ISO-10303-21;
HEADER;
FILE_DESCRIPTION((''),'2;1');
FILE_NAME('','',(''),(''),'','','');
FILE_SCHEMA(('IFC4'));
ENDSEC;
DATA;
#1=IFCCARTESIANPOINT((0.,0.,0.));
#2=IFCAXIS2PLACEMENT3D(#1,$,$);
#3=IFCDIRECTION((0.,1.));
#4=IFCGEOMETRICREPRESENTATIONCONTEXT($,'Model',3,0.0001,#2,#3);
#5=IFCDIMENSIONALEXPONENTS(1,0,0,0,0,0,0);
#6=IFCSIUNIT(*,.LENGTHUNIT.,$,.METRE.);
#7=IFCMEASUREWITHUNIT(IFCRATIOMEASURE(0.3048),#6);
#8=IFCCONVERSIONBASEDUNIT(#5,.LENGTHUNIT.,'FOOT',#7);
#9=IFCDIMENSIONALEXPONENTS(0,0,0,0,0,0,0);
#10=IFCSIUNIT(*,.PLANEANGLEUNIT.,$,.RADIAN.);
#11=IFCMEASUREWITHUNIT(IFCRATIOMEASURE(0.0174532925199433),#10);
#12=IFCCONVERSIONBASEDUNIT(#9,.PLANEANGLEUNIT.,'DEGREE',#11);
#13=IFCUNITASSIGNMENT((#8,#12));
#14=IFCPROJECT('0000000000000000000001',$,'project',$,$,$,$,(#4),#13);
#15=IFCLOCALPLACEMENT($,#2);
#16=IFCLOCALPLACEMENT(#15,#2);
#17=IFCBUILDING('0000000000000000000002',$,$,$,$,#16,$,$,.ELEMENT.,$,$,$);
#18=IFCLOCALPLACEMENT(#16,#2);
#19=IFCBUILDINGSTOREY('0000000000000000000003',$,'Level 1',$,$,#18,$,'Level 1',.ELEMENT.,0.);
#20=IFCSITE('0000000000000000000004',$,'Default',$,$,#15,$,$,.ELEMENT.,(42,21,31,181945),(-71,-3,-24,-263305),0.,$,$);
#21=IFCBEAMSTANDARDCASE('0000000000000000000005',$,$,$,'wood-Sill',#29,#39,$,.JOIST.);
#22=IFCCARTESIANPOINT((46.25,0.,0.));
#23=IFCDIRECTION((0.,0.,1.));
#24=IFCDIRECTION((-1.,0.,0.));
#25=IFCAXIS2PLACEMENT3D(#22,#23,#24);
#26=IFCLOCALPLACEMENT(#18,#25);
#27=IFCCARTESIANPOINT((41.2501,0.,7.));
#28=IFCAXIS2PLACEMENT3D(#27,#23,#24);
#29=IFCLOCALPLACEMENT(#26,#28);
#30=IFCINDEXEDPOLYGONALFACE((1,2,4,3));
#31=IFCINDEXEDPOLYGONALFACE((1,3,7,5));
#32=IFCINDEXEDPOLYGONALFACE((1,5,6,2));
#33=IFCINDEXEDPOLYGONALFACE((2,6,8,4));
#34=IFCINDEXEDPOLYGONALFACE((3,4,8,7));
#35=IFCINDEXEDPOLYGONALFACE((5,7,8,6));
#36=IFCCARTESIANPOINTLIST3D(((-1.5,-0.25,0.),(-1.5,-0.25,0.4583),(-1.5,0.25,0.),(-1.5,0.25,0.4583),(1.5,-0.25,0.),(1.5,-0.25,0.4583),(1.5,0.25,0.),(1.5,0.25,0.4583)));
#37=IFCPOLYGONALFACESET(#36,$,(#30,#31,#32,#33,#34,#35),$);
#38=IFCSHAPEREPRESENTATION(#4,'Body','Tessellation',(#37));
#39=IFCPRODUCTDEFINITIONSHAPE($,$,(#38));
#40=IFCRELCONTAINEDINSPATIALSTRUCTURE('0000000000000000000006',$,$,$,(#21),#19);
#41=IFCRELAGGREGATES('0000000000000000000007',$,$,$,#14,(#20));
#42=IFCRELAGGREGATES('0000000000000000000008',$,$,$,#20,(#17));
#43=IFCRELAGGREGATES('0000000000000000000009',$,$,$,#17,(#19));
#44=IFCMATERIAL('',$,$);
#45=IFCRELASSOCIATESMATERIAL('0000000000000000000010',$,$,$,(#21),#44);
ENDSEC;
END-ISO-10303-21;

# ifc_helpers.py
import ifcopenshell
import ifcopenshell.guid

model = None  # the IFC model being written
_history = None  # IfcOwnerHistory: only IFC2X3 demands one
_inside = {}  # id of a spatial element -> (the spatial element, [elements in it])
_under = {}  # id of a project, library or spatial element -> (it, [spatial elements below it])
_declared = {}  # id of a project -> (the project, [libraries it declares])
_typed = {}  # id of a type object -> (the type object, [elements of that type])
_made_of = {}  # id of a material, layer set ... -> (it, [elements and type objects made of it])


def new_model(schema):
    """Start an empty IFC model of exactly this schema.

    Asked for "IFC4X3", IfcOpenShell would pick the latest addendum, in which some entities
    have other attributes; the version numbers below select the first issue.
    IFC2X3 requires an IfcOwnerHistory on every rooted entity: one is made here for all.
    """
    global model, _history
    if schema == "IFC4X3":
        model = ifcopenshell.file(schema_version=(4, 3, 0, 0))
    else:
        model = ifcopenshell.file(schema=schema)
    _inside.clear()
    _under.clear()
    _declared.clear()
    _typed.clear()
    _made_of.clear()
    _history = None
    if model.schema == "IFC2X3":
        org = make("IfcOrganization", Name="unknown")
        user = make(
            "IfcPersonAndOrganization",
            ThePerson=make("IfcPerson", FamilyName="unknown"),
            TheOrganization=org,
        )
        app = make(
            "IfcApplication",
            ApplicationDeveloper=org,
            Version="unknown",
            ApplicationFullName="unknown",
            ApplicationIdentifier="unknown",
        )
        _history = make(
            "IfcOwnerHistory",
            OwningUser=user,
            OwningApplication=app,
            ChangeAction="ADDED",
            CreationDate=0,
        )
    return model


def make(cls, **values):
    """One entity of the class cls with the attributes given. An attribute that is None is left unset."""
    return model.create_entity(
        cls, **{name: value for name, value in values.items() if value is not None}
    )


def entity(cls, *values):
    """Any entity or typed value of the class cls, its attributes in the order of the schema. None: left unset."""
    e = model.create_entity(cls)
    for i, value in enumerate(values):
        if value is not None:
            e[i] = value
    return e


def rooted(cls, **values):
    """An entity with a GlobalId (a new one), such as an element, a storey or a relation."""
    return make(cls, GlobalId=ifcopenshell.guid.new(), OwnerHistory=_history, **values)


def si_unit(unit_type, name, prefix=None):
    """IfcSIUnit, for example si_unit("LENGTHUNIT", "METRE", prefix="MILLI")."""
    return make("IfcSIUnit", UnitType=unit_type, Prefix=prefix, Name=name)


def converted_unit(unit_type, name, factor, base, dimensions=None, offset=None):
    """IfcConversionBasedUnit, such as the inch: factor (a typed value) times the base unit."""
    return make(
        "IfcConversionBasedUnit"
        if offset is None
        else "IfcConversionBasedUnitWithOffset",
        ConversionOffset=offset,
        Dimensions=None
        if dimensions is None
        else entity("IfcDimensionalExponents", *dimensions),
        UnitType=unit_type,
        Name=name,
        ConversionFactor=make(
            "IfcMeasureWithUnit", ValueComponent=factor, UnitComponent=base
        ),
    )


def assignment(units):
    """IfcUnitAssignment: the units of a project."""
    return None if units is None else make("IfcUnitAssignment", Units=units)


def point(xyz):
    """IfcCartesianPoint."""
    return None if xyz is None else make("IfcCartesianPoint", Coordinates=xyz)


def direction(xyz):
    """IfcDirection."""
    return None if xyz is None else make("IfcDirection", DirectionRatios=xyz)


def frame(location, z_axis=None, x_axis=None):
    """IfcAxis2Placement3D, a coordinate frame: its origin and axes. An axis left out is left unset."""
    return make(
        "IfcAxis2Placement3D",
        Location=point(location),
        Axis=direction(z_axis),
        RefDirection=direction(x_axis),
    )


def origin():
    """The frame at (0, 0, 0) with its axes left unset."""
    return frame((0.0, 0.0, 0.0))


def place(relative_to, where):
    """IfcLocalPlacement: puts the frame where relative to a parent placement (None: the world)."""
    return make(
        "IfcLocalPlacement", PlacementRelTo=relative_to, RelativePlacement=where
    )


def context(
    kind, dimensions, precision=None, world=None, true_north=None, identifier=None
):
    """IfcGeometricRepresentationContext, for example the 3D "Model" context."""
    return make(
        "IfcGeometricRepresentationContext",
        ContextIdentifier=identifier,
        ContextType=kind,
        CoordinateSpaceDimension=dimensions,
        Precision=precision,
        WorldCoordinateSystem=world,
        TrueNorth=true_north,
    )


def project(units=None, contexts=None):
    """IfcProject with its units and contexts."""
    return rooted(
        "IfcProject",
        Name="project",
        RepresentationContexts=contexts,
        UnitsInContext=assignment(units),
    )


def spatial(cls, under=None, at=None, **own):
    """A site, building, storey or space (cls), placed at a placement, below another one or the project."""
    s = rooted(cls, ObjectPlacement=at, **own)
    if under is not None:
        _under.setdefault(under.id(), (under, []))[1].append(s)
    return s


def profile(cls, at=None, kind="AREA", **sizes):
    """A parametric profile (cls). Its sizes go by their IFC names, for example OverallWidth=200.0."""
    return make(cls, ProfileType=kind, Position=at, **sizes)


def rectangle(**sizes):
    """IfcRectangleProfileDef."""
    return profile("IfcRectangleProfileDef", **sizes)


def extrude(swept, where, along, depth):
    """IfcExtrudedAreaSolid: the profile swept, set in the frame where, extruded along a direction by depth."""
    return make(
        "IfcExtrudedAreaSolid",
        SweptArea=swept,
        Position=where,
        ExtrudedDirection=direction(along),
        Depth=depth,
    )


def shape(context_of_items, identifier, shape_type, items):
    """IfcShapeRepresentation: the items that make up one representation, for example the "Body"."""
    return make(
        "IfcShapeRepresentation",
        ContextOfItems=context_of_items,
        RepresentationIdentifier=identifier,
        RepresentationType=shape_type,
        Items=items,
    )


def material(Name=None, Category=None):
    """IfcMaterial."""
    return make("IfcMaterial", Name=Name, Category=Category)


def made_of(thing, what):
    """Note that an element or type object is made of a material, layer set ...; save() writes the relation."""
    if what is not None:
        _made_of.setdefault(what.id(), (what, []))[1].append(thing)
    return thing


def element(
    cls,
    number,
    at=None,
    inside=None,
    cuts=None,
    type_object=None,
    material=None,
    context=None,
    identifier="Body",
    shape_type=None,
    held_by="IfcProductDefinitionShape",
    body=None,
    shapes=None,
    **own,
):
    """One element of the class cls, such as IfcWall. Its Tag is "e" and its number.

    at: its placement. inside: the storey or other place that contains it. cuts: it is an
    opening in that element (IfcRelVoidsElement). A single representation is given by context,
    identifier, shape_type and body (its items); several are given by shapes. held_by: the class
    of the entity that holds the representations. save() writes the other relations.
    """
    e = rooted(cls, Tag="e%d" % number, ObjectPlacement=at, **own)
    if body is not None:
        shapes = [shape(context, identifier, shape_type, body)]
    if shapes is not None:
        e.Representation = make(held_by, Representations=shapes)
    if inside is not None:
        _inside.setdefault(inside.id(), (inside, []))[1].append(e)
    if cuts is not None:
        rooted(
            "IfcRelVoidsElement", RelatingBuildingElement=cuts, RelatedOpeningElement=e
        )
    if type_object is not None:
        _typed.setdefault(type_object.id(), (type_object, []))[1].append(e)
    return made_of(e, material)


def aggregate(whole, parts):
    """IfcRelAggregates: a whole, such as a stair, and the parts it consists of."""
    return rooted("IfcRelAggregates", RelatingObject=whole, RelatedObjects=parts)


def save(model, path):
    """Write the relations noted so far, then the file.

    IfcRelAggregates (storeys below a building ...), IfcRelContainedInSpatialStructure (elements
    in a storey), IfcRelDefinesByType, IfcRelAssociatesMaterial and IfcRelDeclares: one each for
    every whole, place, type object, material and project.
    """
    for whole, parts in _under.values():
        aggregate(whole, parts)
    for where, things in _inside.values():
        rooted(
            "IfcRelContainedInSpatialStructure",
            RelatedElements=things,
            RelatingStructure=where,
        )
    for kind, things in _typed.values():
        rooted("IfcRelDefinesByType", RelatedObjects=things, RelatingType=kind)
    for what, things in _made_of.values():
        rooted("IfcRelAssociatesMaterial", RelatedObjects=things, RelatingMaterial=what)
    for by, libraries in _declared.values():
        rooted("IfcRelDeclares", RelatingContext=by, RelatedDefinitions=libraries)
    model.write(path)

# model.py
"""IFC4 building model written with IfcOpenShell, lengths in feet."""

from ifc_helpers import new_model, entity, si_unit, converted_unit, direction, frame, origin, place, context, project, spatial, rectangle, extrude, material, element, save


model = new_model("IFC4")

# Units and contexts
model_context = context("Model", 3, precision=0.0001, world=origin(), true_north=direction((0.0, 1.0)))
ifc_project = project(units=[converted_unit("LENGTHUNIT", "FOOT", entity("IfcRatioMeasure", 0.3048), si_unit("LENGTHUNIT", "METRE"), dimensions=[1, 0, 0, 0, 0, 0, 0]), converted_unit("PLANEANGLEUNIT", "DEGREE", entity("IfcRatioMeasure", 0.0174532925199433), si_unit("PLANEANGLEUNIT", "RADIAN"), dimensions=[0, 0, 0, 0, 0, 0, 0])], contexts=[model_context])

# Site, building, storey
site_placement = place(None, origin())
site = spatial("IfcSite", under=ifc_project, at=site_placement, Name="Default", CompositionType="ELEMENT", RefLatitude=(42, 21, 31, 181945), RefLongitude=(-71, -3, -24, -263305), RefElevation=0.0)
building_placement = place(site_placement, origin())
building = spatial("IfcBuilding", under=site, at=building_placement, CompositionType="ELEMENT")
storey_placement = place(building_placement, origin())
storey = spatial("IfcBuildingStorey", under=building, at=storey_placement, Name="Level 1", LongName="Level 1", CompositionType="ELEMENT", Elevation=0.0)

# Shared definitions
placement_1 = place(storey_placement, frame((46.25, 0.0, 0.0), z_axis=(0.0, 0.0, 1.0), x_axis=(-1.0, 0.0, 0.0)))

# Beam
ifc_material_1 = material(Name="")
beam_1_placement = place(placement_1, frame((41.2501, 0.0, 7.0), z_axis=(0.0, 0.0, 1.0), x_axis=(-1.0, 0.0, 0.0)))
element("IfcBeamStandardCase", 1, at=beam_1_placement, inside=storey, material=ifc_material_1, ObjectType="wood-Sill", PredefinedType="JOIST", context=model_context, shape_type="SweptSolid", body=[
    extrude(rectangle(XDim=3.0, YDim=0.5), origin(), (0.0, 0.0, 1.0), 0.4583),
])

save(model, "model.ifc")
